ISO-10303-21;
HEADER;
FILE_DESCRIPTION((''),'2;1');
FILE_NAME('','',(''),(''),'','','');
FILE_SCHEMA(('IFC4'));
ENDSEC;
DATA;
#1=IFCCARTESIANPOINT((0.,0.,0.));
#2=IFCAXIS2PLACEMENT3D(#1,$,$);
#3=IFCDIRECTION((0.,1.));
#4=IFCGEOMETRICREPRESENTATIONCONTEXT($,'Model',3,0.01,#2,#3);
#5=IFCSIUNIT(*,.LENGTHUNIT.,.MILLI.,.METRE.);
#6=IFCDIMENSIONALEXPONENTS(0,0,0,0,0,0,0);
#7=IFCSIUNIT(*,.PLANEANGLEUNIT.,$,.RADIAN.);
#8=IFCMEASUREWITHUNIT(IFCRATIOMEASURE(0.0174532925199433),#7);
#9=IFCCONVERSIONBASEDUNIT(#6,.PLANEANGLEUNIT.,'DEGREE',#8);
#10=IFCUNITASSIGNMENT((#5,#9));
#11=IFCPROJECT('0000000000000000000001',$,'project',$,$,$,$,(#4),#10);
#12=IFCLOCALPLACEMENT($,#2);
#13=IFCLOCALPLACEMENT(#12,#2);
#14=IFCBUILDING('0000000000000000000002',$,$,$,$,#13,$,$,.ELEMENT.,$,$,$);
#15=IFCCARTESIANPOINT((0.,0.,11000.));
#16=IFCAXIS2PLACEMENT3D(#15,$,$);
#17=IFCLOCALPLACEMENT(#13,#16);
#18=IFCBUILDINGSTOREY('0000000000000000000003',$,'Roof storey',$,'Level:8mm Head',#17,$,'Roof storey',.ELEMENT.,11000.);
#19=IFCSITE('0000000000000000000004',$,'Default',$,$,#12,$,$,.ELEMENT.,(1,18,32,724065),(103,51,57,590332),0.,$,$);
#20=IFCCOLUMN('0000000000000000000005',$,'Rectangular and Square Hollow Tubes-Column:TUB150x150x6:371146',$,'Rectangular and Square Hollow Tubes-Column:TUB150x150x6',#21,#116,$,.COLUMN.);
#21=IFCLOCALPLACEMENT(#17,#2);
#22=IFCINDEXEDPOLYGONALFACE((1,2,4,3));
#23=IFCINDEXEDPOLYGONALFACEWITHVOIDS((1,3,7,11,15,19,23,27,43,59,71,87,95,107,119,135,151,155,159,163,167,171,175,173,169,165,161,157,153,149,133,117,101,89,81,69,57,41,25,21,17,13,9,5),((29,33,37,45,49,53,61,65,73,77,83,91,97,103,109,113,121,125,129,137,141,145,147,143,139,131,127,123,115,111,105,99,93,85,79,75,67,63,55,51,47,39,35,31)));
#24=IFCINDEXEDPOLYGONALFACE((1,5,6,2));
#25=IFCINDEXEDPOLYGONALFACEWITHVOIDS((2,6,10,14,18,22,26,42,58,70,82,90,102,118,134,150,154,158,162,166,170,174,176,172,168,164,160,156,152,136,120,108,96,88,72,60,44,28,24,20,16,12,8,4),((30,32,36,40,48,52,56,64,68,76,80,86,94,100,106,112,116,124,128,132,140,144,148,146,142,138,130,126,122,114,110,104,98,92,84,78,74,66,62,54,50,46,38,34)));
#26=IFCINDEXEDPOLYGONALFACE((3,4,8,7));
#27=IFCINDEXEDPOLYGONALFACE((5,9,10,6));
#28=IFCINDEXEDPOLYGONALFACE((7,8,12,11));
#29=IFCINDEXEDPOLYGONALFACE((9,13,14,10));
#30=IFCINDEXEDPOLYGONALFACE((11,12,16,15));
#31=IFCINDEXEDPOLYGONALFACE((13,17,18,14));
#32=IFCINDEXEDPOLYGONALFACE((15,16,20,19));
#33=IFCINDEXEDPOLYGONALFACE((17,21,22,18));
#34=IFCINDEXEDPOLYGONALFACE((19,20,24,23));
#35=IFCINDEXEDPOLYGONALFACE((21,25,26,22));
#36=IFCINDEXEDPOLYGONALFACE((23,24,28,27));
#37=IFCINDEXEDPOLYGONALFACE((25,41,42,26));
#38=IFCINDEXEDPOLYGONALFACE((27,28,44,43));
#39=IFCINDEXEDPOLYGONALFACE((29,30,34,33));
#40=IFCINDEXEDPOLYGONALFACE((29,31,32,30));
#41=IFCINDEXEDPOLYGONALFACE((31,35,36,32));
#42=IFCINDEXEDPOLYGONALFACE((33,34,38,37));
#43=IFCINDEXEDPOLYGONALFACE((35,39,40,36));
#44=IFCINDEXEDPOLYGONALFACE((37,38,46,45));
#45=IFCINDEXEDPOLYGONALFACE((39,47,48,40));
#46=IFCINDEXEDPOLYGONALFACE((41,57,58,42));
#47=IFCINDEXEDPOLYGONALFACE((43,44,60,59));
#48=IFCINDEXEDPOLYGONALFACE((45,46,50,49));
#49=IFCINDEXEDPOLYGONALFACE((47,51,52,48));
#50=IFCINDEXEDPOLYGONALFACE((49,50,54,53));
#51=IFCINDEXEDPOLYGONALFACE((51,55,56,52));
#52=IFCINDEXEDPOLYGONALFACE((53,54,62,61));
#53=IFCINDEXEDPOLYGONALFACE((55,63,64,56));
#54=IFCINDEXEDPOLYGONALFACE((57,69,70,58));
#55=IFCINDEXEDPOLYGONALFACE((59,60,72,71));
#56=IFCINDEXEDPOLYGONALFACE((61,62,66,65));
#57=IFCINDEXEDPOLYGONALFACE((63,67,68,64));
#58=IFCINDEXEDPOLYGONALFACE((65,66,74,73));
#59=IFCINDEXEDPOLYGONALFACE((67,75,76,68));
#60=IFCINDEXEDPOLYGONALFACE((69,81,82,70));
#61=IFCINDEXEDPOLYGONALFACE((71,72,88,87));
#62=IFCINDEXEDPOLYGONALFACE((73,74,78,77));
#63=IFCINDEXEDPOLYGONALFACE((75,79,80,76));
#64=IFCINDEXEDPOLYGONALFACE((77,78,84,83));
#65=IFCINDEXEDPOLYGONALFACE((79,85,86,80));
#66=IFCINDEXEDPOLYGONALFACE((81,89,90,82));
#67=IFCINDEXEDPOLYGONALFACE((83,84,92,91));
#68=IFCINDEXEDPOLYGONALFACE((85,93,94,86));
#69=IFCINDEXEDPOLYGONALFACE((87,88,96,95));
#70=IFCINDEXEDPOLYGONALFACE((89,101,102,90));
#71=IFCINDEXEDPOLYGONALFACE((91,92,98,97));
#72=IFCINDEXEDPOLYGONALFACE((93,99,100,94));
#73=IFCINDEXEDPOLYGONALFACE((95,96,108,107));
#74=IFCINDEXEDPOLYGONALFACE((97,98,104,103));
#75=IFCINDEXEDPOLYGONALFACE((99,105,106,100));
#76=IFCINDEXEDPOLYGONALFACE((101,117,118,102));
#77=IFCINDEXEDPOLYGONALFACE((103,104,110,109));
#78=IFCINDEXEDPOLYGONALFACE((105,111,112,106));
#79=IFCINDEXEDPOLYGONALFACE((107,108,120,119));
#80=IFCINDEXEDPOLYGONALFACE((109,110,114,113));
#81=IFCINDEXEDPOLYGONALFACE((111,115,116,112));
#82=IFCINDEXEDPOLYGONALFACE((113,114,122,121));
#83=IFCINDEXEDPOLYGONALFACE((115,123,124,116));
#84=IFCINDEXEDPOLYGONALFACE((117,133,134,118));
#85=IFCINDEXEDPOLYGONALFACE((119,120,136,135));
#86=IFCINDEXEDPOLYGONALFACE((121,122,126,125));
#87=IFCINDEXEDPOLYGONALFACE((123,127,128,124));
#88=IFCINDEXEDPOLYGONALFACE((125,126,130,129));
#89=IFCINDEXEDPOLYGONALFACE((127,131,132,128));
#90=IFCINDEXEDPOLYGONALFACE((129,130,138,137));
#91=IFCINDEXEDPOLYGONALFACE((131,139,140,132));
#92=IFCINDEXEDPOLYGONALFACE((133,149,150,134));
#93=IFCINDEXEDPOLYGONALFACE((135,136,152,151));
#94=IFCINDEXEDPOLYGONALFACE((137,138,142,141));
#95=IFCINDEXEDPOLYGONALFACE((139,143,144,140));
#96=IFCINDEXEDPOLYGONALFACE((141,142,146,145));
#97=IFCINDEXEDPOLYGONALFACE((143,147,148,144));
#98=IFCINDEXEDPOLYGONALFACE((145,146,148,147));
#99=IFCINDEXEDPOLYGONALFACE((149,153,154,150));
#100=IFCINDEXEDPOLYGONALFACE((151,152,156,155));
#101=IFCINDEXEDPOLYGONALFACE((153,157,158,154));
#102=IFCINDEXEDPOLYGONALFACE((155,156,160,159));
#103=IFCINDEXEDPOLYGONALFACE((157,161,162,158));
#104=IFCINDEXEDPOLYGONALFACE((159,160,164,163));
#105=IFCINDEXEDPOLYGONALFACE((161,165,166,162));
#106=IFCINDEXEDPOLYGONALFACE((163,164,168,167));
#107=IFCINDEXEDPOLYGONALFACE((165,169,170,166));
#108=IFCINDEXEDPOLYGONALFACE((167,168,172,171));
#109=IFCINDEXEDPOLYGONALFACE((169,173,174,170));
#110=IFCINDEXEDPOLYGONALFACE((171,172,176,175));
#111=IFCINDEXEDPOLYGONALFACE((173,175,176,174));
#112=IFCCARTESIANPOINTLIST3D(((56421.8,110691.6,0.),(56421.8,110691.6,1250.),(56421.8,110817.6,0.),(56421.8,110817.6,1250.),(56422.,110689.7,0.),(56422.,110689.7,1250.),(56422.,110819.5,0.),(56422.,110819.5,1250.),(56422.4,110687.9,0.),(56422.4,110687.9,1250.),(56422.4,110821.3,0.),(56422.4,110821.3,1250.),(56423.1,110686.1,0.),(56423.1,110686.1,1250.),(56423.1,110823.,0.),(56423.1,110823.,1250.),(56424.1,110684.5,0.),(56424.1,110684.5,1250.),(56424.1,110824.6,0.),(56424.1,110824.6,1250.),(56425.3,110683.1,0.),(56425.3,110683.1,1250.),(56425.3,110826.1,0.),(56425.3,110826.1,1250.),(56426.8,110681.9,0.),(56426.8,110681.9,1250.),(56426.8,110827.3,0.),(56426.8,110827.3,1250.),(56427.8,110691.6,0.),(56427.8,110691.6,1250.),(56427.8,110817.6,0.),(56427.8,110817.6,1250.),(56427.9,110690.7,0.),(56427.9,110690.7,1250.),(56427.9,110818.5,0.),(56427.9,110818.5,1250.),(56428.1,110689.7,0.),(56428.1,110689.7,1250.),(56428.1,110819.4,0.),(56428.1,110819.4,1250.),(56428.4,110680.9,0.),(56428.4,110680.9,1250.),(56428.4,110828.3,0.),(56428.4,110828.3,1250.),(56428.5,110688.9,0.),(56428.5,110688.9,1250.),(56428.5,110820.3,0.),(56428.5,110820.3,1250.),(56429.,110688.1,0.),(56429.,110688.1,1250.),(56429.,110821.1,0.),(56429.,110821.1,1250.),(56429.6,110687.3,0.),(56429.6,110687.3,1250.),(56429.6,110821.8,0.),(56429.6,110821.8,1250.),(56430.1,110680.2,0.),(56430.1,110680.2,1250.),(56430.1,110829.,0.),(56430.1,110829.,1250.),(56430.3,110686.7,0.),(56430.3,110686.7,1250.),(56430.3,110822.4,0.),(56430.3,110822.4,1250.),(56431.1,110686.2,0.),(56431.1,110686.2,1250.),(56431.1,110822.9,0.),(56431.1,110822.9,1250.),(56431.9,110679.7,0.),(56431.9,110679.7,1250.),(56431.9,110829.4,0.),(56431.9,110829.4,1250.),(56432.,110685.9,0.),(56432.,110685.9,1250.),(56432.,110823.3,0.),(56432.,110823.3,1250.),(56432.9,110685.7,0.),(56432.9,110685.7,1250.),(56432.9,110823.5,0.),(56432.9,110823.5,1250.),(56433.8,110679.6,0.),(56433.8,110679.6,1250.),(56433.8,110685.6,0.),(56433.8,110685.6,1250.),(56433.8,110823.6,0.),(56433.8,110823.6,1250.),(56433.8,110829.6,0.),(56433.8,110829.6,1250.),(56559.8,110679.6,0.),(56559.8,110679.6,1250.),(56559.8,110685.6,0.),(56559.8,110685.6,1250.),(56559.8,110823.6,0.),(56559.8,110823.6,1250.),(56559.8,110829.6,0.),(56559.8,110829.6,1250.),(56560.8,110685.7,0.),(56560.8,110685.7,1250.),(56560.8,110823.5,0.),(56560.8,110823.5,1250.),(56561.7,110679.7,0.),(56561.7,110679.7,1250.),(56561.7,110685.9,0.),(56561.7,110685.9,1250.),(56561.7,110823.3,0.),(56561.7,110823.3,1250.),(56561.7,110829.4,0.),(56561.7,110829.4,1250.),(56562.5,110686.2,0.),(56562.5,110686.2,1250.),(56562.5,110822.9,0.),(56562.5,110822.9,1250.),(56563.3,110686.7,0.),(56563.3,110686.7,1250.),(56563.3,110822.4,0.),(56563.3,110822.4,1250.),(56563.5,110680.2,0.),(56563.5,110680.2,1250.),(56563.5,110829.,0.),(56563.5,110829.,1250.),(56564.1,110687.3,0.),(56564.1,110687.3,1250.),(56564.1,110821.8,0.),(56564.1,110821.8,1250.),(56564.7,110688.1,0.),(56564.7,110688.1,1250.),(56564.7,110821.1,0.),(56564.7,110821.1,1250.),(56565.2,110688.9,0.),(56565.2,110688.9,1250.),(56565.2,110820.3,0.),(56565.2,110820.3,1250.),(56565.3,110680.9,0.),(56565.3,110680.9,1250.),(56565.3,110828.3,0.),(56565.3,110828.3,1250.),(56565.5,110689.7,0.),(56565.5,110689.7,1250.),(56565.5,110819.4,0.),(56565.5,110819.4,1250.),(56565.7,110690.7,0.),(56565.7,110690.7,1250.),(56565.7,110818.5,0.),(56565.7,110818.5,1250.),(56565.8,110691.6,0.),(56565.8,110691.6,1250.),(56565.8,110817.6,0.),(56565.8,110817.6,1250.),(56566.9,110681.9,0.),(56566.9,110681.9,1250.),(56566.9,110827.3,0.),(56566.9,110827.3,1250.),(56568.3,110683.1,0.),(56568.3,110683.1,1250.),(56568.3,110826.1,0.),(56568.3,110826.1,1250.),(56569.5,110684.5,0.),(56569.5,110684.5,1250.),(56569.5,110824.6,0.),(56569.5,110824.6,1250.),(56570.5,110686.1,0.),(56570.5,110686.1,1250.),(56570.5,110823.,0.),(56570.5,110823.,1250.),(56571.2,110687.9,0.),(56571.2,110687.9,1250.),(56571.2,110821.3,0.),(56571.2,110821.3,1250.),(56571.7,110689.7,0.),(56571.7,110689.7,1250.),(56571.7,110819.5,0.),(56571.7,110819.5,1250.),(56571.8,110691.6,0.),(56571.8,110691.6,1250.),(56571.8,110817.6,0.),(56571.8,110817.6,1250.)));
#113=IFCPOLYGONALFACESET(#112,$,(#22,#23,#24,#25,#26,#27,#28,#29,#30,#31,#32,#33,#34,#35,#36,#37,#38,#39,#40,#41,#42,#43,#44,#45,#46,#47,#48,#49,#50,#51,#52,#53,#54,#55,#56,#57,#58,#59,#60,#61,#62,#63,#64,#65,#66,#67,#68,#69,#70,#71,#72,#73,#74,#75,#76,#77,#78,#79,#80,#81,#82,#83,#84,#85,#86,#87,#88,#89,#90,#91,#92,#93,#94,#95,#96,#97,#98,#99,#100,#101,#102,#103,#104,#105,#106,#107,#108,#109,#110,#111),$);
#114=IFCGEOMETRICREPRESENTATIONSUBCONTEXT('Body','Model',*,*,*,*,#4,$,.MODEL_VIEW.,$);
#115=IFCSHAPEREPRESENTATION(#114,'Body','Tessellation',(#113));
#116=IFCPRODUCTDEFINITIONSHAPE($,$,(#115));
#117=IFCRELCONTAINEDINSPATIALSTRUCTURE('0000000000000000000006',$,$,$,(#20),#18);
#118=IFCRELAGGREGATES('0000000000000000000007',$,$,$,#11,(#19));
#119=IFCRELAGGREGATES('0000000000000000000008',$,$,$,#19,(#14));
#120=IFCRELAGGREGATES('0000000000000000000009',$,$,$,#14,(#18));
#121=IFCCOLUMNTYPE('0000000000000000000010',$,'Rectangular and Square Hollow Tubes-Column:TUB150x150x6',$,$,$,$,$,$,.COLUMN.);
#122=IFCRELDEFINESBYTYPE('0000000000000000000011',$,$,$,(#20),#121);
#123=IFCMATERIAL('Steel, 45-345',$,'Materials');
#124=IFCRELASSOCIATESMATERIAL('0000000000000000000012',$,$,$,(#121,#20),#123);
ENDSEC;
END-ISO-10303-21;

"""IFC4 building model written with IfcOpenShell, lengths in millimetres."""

from ifc_helpers import new_model, entity, si_unit, converted_unit, direction, frame, origin, place, context, subcontext, project, spatial, indexed_curve, outline, extrude, source, transform, mapped, material, type_object, type_shapes, element, save


model = new_model("IFC4")

# Units and contexts
model_context = context("Model", 3, precision=0.01, world=origin(), true_north=direction((0.0, 1.0)))
body_context = subcontext(model_context, "Body", "Model", "MODEL_VIEW")
ifc_project = project(units=[si_unit("LENGTHUNIT", "METRE", prefix="MILLI"), converted_unit("PLANEANGLEUNIT", "DEGREE", entity("IfcRatioMeasure", 0.0174532925199433), si_unit("PLANEANGLEUNIT", "RADIAN"), dimensions=[0, 0, 0, 0, 0, 0, 0])], contexts=[model_context])

# Site, building, storey
site_placement = place(None, origin())
site = spatial("IfcSite", under=ifc_project, at=site_placement, Name="Default", CompositionType="ELEMENT", RefLatitude=(1, 18, 32, 724065), RefLongitude=(103, 51, 57, 590332), RefElevation=0.0)
building_placement = place(site_placement, origin())
building = spatial("IfcBuilding", under=site, at=building_placement, CompositionType="ELEMENT")
storey_placement = place(building_placement, frame((0.0, 0.0, 11000.0)))
storey = spatial("IfcBuildingStorey", under=building, at=storey_placement, Name="Roof storey", ObjectType="Level:8mm Head", LongName="Roof storey", CompositionType="ELEMENT", Elevation=11000.0)

# Column
ifc_material = material(Name="Steel, 45-345", Category="Materials")
column_type = type_object("IfcColumnType", Name="Rectangular and Square Hollow Tubes-Column:TUB150x150x6", PredefinedType="COLUMN", material=ifc_material)
shared_shape_1 = source(origin(), body_context, "Body", "SweptSolid", [
    extrude(outline(indexed_curve([(-63.0, -75.0), (63.0, -75.0), (64.9, -74.9), (66.7, -74.4), (68.4, -73.7), (70.1, -72.7), (71.5, -71.5), (72.7, -70.1), (73.7, -68.4), (74.4, -66.7), (74.9, -64.9), (75.0, -63.0), (75.0, 63.0), (74.9, 64.9), (74.4, 66.7), (73.7, 68.4), (72.7, 70.1), (71.5, 71.5), (70.1, 72.7), (68.4, 73.7), (66.7, 74.4), (64.9, 74.9), (63.0, 75.0), (-63.0, 75.0), (-64.9, 74.9), (-66.7, 74.4), (-68.4, 73.7), (-70.1, 72.7), (-71.5, 71.5), (-72.7, 70.1), (-73.7, 68.4), (-74.4, 66.7), (-74.9, 64.9), (-75.0, 63.0), (-75.0, -63.0), (-74.9, -64.9), (-74.4, -66.7), (-73.7, -68.4), (-72.7, -70.1), (-71.5, -71.5), (-70.1, -72.7), (-68.4, -73.7), (-66.7, -74.4), (-64.9, -74.9), (-63.0, -75.0)], self_intersect=False), holes=[indexed_curve([(-63.0, -69.0), (-63.9, -68.9), (-64.9, -68.7), (-65.7, -68.3), (-66.5, -67.9), (-67.2, -67.2), (-67.9, -66.5), (-68.3, -65.7), (-68.7, -64.9), (-68.9, -63.9), (-69.0, -63.0), (-69.0, 63.0), (-68.9, 63.9), (-68.7, 64.9), (-68.3, 65.7), (-67.9, 66.5), (-67.2, 67.2), (-66.5, 67.9), (-65.7, 68.3), (-64.9, 68.7), (-63.9, 68.9), (-63.0, 69.0), (63.0, 69.0), (63.9, 68.9), (64.9, 68.7), (65.7, 68.3), (66.5, 67.9), (67.2, 67.2), (67.9, 66.5), (68.3, 65.7), (68.7, 64.9), (68.9, 63.9), (69.0, 63.0), (69.0, -63.0), (68.9, -63.9), (68.7, -64.9), (68.3, -65.7), (67.9, -66.5), (67.2, -67.2), (66.5, -67.9), (65.7, -68.3), (64.9, -68.7), (63.9, -68.9), (63.0, -69.0), (-63.0, -69.0)], self_intersect=False)]), frame((0.0, 0.0, 11000.0), z_axis=(0.0, 0.0, 1.0), x_axis=(-1.0, 0.0, 0.0)), (0.0, 0.0, 1.0), 1250.0),
])
type_shapes(column_type, [shared_shape_1])
for number, where, name in (
    (1, (56496.8, 110754.6, -11000.0), "Rectangular and Square Hollow Tubes-Column:TUB150x150x6:371146"),
):
    element("IfcColumn", number, at=place(storey_placement, frame(where)), inside=storey, type_object=column_type, material=ifc_material, Name=name, ObjectType="Rectangular and Square Hollow Tubes-Column:TUB150x150x6", PredefinedType="COLUMN", context=body_context, shape_type="MappedRepresentation", body=[
        mapped(shared_shape_1, transform((0.0, 0.0, 0.0), scale=1.0)),
    ])

save(model, "model.ifc")
